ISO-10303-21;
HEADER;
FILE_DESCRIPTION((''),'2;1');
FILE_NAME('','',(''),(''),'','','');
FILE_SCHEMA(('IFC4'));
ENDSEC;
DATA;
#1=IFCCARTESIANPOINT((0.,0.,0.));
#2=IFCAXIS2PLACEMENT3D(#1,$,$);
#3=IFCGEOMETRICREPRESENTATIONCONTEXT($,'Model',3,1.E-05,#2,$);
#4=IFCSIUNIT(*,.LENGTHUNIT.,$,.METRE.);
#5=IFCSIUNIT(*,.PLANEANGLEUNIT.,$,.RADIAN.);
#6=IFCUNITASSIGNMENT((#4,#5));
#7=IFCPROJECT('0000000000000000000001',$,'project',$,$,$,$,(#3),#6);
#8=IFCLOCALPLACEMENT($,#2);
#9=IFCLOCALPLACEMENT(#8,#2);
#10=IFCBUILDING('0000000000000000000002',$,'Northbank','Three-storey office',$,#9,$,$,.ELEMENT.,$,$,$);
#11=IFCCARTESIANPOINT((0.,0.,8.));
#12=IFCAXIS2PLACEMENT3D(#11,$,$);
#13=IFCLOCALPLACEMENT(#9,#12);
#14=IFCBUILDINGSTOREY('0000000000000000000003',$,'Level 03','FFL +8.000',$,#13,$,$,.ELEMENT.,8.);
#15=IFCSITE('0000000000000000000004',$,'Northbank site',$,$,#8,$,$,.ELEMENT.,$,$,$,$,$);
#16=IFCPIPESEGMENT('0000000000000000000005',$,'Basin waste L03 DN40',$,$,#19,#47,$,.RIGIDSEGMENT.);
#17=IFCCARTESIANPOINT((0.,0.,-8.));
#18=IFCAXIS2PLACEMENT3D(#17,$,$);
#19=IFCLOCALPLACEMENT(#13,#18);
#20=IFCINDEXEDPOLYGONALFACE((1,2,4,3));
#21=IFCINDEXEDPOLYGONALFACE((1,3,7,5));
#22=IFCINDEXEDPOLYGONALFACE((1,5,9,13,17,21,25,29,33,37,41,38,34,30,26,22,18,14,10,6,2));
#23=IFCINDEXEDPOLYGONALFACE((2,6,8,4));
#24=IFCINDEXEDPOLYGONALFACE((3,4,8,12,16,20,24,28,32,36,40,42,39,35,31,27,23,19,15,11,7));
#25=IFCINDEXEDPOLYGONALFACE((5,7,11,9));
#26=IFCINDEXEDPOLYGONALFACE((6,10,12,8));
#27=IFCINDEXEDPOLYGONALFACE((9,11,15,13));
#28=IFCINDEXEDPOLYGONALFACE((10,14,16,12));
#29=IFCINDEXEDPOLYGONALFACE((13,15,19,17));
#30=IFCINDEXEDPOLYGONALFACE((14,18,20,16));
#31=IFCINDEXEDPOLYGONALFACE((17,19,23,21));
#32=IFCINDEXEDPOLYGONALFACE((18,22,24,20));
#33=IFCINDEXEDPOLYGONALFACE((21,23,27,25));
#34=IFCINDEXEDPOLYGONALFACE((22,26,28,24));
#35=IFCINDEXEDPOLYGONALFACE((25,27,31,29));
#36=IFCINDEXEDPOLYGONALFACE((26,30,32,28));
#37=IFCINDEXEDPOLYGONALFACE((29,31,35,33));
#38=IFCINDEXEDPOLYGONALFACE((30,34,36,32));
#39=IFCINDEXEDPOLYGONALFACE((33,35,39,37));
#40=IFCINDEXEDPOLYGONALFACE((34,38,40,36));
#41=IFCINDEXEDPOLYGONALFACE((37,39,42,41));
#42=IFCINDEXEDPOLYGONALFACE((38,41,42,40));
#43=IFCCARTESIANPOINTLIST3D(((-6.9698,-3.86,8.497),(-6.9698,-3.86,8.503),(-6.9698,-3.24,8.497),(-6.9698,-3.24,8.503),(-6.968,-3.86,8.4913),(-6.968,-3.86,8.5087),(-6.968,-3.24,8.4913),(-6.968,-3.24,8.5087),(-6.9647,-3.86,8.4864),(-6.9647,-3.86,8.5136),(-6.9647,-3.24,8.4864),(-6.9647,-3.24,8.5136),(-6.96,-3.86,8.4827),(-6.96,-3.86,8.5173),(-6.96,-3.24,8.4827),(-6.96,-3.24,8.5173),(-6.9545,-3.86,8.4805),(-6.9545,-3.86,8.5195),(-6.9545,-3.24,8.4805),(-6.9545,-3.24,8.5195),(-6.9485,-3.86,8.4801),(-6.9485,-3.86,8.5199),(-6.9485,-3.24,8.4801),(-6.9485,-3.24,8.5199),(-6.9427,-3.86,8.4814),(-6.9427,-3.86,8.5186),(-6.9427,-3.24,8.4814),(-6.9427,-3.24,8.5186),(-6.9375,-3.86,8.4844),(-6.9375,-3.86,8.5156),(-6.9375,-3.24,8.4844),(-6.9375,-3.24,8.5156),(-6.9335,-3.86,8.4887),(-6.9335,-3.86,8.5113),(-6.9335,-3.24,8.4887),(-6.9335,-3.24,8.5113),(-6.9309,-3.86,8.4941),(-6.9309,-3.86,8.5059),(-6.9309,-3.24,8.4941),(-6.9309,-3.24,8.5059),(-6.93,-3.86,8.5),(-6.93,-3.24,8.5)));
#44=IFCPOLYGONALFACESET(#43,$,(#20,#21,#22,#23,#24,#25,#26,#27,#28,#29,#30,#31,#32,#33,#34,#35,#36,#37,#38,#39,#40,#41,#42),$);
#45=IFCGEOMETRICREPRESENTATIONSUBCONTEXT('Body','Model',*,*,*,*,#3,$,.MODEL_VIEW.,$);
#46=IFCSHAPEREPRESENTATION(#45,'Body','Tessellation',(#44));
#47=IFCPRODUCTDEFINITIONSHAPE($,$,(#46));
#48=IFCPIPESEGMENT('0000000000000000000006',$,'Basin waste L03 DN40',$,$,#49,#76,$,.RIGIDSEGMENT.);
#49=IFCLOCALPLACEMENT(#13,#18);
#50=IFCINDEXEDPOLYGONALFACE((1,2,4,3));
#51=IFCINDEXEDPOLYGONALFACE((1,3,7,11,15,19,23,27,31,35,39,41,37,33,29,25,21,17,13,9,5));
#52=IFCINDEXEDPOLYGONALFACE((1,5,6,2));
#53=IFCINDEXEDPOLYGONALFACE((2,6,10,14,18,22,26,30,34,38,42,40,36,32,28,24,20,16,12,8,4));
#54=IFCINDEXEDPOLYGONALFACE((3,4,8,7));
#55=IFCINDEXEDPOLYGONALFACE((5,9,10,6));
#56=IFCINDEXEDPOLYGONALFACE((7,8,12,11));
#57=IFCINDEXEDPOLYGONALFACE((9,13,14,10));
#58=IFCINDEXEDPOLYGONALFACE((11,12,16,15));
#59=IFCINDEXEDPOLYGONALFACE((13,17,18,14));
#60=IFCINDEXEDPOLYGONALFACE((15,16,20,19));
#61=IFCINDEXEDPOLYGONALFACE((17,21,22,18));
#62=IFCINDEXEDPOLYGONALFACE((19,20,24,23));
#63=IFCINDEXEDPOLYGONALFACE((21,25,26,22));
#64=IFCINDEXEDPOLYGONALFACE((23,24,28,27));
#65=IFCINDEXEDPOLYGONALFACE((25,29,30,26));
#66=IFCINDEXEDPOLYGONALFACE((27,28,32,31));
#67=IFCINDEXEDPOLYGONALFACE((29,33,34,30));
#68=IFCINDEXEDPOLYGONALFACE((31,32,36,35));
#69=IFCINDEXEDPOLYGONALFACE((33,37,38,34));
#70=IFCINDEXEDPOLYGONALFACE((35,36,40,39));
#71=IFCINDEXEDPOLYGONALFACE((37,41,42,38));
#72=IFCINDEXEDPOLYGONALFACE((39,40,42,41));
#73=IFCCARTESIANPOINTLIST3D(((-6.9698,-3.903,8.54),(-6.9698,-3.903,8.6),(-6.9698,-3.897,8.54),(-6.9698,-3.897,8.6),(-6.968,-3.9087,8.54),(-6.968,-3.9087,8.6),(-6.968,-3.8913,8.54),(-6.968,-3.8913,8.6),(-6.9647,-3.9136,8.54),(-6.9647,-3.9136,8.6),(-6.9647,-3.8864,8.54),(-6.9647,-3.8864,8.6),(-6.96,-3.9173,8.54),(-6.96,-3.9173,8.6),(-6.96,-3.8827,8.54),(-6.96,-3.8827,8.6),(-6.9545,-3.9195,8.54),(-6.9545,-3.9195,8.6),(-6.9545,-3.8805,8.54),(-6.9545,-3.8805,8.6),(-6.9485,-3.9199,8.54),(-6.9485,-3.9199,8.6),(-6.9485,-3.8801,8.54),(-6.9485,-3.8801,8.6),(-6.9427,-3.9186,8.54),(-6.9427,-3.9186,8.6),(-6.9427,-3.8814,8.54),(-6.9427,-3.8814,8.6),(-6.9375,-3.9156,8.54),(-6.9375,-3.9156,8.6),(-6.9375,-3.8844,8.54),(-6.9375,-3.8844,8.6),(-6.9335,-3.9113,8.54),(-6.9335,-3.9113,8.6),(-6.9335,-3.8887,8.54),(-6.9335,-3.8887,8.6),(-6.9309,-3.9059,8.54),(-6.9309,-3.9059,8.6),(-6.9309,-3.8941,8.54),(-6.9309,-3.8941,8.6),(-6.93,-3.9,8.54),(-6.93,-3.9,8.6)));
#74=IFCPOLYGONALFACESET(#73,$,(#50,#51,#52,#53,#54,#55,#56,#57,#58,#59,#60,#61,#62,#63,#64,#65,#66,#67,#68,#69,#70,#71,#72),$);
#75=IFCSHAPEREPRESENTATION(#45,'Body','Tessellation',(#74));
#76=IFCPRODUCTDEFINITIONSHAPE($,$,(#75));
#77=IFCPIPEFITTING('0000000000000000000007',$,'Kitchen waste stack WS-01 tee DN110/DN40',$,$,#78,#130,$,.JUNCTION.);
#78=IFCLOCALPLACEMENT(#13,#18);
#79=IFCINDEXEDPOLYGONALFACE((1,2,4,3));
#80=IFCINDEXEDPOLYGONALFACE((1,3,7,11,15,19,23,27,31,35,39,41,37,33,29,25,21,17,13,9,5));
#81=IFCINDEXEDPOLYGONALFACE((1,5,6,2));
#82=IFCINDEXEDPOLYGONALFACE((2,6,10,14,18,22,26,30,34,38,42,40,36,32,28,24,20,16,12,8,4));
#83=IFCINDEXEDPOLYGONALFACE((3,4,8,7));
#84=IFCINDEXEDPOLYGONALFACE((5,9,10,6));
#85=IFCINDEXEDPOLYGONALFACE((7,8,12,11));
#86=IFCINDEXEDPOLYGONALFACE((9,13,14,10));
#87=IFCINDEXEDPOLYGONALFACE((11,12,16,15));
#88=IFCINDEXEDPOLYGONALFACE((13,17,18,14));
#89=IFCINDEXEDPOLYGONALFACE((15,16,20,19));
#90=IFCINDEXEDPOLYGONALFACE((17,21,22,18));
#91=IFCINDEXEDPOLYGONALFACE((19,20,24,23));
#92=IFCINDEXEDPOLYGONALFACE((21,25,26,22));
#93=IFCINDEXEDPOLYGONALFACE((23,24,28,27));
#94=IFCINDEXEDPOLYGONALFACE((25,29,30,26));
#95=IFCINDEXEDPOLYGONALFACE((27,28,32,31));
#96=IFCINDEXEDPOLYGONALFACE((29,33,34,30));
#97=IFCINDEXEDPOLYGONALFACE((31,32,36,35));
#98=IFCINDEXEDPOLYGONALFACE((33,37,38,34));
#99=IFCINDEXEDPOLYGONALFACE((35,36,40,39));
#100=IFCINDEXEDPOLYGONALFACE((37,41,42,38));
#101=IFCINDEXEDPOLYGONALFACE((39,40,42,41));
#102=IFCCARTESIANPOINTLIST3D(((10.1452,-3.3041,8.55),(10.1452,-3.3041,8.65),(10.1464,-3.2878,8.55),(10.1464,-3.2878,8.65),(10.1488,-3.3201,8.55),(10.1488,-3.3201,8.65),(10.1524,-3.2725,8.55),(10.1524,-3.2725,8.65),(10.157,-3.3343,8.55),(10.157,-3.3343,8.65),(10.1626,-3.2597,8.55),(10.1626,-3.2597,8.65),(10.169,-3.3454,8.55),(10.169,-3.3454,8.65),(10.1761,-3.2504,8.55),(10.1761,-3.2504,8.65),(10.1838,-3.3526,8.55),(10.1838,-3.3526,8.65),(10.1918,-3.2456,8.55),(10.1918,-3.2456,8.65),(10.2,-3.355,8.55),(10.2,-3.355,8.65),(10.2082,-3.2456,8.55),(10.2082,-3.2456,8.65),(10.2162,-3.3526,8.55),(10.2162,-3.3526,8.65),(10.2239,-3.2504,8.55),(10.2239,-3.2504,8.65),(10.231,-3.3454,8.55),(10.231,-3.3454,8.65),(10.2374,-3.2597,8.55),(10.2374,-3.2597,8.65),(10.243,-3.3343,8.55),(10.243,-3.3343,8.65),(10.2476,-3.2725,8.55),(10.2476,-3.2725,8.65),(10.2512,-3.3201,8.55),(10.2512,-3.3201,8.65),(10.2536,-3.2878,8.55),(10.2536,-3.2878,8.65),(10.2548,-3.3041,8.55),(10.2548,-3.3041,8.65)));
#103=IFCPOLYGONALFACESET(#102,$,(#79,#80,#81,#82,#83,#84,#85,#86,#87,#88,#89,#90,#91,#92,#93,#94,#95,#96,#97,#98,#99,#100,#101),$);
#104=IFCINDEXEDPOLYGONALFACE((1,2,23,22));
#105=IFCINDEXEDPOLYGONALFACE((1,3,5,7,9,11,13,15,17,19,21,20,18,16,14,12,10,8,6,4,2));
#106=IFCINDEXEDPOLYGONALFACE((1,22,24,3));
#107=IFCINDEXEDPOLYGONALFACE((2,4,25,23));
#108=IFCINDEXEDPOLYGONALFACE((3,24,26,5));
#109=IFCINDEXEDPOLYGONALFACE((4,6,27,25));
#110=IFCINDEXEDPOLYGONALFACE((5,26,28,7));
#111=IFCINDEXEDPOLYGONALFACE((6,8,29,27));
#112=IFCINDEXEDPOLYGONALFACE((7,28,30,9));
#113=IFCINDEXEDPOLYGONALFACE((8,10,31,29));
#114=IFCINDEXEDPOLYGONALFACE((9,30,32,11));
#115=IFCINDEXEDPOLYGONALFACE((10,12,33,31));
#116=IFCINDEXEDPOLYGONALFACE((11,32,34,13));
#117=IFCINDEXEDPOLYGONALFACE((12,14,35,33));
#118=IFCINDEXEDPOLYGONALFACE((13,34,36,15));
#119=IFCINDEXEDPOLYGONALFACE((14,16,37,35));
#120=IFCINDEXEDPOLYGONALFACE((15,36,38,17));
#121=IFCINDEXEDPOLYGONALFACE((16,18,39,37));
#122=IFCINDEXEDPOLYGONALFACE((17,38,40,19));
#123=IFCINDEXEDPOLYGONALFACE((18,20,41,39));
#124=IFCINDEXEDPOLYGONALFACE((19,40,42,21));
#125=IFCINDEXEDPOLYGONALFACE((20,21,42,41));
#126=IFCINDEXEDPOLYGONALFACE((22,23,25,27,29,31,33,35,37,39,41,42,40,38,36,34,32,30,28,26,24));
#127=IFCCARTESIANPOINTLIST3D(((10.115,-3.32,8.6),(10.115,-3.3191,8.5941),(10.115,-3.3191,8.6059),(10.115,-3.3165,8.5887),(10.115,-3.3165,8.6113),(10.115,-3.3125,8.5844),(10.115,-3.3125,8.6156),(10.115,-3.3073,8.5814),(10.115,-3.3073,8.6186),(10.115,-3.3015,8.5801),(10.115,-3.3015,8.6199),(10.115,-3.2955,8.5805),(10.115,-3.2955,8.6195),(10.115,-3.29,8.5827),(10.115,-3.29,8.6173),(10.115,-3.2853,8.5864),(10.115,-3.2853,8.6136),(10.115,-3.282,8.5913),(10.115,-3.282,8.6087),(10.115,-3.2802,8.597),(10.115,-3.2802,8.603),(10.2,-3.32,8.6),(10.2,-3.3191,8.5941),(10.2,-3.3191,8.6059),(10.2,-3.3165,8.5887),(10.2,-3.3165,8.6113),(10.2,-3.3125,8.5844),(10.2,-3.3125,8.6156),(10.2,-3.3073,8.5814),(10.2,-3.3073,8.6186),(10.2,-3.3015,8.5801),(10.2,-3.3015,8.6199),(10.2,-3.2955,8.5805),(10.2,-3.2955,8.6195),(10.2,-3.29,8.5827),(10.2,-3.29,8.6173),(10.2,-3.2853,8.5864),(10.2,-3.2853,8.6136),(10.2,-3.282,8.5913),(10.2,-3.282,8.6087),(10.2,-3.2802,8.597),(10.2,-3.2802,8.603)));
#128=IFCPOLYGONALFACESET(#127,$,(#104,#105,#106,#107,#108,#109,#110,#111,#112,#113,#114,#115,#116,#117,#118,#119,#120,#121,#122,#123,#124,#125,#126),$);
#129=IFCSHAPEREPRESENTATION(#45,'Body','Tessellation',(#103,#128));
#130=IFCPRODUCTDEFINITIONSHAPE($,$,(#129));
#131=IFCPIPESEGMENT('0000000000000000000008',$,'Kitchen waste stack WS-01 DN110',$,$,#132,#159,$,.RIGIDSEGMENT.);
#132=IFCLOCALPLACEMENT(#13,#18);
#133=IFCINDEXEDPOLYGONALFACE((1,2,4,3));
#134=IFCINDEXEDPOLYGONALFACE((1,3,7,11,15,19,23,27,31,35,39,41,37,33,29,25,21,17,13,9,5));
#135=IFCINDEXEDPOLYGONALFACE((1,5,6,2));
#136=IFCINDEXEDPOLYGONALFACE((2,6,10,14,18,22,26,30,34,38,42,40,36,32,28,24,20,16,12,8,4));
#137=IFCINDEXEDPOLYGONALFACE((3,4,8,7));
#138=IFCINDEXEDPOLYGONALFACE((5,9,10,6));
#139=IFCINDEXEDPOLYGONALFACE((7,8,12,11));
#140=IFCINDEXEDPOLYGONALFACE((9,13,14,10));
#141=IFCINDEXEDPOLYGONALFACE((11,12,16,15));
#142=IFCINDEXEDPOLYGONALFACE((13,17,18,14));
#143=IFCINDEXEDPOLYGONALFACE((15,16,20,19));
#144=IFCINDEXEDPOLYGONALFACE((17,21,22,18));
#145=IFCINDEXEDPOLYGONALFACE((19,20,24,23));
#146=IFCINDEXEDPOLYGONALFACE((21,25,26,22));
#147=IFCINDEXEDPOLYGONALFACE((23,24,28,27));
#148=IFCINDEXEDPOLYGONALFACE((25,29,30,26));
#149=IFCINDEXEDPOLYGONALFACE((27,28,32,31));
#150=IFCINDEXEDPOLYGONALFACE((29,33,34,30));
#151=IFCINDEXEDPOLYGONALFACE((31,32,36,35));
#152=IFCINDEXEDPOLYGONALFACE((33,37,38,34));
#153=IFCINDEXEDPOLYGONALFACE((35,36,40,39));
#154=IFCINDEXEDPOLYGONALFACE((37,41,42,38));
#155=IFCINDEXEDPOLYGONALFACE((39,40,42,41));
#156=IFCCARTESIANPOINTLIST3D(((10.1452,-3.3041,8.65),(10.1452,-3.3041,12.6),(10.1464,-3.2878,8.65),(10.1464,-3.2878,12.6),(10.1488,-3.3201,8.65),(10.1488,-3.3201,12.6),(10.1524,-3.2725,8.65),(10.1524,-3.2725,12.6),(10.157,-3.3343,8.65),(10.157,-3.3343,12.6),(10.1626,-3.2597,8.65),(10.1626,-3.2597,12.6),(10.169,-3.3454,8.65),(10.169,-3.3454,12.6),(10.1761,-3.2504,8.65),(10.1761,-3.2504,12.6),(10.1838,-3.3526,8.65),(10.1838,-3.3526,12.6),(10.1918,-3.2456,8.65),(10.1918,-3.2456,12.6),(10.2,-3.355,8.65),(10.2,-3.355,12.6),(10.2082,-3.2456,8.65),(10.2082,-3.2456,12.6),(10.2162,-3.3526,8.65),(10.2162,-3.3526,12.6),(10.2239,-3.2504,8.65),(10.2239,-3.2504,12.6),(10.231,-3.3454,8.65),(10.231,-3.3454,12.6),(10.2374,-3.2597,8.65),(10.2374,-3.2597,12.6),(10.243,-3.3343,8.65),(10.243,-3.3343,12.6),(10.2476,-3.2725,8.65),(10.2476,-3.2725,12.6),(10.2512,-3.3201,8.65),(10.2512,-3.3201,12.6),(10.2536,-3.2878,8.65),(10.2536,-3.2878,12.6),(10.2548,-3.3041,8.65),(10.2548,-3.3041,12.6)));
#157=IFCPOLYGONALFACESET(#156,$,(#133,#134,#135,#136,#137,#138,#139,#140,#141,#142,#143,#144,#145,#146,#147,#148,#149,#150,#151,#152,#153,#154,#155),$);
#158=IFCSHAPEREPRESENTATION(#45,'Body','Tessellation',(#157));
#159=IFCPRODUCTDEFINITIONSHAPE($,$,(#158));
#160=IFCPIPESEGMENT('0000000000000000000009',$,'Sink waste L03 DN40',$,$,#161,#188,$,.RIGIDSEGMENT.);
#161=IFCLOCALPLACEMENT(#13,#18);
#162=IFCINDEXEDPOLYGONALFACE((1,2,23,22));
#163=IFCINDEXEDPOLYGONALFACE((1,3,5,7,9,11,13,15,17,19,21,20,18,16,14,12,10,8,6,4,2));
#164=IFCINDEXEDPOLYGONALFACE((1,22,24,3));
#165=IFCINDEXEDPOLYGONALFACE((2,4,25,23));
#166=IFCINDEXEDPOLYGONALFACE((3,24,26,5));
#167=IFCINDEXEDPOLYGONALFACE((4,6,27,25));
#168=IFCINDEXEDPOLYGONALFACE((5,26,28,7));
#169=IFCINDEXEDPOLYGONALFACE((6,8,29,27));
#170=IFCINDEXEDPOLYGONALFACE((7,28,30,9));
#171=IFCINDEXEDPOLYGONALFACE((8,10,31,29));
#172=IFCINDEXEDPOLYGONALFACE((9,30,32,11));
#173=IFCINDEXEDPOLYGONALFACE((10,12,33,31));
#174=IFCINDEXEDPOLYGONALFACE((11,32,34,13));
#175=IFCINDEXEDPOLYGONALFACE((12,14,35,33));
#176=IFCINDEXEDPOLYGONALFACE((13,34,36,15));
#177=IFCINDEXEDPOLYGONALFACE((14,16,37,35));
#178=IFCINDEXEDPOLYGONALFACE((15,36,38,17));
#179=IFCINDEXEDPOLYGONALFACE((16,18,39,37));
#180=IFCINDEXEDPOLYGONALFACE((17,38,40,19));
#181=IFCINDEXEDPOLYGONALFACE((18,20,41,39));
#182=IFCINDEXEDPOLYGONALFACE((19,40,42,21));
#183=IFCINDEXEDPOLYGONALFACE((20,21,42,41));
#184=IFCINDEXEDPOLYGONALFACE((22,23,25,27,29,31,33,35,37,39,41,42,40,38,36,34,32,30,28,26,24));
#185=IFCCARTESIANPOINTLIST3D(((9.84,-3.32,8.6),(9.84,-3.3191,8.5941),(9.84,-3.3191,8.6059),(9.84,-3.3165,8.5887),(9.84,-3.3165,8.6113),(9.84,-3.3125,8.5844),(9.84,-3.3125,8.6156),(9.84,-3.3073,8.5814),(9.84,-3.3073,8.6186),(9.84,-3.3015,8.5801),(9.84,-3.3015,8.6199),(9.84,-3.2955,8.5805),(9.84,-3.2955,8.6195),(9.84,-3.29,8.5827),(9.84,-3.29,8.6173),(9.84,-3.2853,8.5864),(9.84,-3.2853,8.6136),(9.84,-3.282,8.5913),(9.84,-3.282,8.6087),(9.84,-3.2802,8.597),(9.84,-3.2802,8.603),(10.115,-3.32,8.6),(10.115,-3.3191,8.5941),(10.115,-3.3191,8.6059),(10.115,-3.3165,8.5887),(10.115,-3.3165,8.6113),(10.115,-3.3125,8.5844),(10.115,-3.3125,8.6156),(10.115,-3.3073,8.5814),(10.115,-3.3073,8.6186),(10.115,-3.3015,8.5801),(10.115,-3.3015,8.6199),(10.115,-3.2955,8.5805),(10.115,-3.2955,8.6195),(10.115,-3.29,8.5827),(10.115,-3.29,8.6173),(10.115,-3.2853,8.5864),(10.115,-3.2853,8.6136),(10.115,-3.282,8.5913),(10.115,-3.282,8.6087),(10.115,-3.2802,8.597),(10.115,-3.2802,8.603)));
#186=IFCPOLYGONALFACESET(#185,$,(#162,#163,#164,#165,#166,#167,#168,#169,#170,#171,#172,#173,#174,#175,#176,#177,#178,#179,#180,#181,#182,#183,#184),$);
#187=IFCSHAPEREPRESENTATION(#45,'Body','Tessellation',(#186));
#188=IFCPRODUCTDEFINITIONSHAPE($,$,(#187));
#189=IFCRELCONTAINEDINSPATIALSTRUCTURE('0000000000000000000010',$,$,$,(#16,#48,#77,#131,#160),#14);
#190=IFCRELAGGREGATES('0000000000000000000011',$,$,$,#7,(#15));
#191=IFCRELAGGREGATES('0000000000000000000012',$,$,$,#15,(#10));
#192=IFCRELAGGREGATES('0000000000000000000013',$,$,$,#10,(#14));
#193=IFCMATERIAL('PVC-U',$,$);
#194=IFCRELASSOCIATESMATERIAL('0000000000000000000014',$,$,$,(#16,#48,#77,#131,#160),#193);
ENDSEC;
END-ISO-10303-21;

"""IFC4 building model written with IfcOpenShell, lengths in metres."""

from ifc_helpers import new_model, si_unit, frame, origin, place, context, subcontext, project, spatial, circle, extrude, material, element, save


model = new_model("IFC4")

# Units and contexts
model_context = context("Model", 3, precision=1e-05, world=origin())
body_context = subcontext(model_context, "Body", "Model", "MODEL_VIEW")
ifc_project = project(units=[si_unit("LENGTHUNIT", "METRE"), si_unit("PLANEANGLEUNIT", "RADIAN")], contexts=[model_context])

# Site, building, storey
site_placement = place(None, origin())
site = spatial("IfcSite", under=ifc_project, at=site_placement, Name="Northbank site", CompositionType="ELEMENT")
building_placement = place(site_placement, origin())
building = spatial("IfcBuilding", under=site, at=building_placement, Name="Northbank", Description="Three-storey office", CompositionType="ELEMENT")
storey_placement = place(building_placement, frame((0.0, 0.0, 8.0)))
storey = spatial("IfcBuildingStorey", under=building, at=storey_placement, Name="Level 03", Description="FFL +8.000", CompositionType="ELEMENT", Elevation=8.0)

# Shared definitions
ifc_material_1 = material(Name="PVC-U")

# Pipe segments
pipe_segment_1_placement = place(storey_placement, frame((0.0, 0.0, -8.0)))
element("IfcPipeSegment", 1, at=pipe_segment_1_placement, inside=storey, material=ifc_material_1, Name="Basin waste L03 DN40", PredefinedType="RIGIDSEGMENT", context=body_context, shape_type="SweptSolid", body=[
    extrude(circle(Radius=0.02), frame((-6.95, -3.24, 8.5), z_axis=(0.0, -1.0, 0.0), x_axis=(1.0, 0.0, 0.0)), (0.0, 0.0, 1.0), 0.62),
])
pipe_segment_2_placement = place(storey_placement, frame((0.0, 0.0, -8.0)))
element("IfcPipeSegment", 2, at=pipe_segment_2_placement, inside=storey, material=ifc_material_1, Name="Basin waste L03 DN40", PredefinedType="RIGIDSEGMENT", context=body_context, shape_type="SweptSolid", body=[
    extrude(circle(Radius=0.02), frame((-6.95, -3.9, 8.54), z_axis=(0.0, 0.0, 1.0), x_axis=(1.0, 0.0, 0.0)), (0.0, 0.0, 1.0), 0.06),
])

# Pipe fitting
pipe_fitting_1_placement = place(storey_placement, frame((0.0, 0.0, -8.0)))
element("IfcPipeFitting", 3, at=pipe_fitting_1_placement, inside=storey, material=ifc_material_1, Name="Kitchen waste stack WS-01 tee DN110/DN40", PredefinedType="JUNCTION", context=body_context, shape_type="SweptSolid", body=[
    extrude(circle(Radius=0.055), frame((10.2, -3.3, 8.55), z_axis=(0.0, 0.0, 1.0), x_axis=(0.0, -1.0, 0.0)), (0.0, 0.0, 1.0), 0.1),
    extrude(circle(Radius=0.02), frame((10.2, -3.3, 8.6), z_axis=(-1.0, 0.0, 0.0), x_axis=(0.0, -1.0, 0.0)), (0.0, 0.0, 1.0), 0.085),
])

# Pipe segments
pipe_segment_3_placement = place(storey_placement, frame((0.0, 0.0, -8.0)))
element("IfcPipeSegment", 4, at=pipe_segment_3_placement, inside=storey, material=ifc_material_1, Name="Kitchen waste stack WS-01 DN110", PredefinedType="RIGIDSEGMENT", context=body_context, shape_type="SweptSolid", body=[
    extrude(circle(Radius=0.055), frame((10.2, -3.3, 8.65), z_axis=(0.0, 0.0, 1.0), x_axis=(0.0, -1.0, 0.0)), (0.0, 0.0, 1.0), 3.95),
])
pipe_segment_4_placement = place(storey_placement, frame((0.0, 0.0, -8.0)))
element("IfcPipeSegment", 5, at=pipe_segment_4_placement, inside=storey, material=ifc_material_1, Name="Sink waste L03 DN40", PredefinedType="RIGIDSEGMENT", context=body_context, shape_type="SweptSolid", body=[
    extrude(circle(Radius=0.02), frame((10.115, -3.3, 8.6), z_axis=(-1.0, 0.0, 0.0), x_axis=(0.0, -1.0, 0.0)), (0.0, 0.0, 1.0), 0.275),
])

save(model, "model.ifc")
